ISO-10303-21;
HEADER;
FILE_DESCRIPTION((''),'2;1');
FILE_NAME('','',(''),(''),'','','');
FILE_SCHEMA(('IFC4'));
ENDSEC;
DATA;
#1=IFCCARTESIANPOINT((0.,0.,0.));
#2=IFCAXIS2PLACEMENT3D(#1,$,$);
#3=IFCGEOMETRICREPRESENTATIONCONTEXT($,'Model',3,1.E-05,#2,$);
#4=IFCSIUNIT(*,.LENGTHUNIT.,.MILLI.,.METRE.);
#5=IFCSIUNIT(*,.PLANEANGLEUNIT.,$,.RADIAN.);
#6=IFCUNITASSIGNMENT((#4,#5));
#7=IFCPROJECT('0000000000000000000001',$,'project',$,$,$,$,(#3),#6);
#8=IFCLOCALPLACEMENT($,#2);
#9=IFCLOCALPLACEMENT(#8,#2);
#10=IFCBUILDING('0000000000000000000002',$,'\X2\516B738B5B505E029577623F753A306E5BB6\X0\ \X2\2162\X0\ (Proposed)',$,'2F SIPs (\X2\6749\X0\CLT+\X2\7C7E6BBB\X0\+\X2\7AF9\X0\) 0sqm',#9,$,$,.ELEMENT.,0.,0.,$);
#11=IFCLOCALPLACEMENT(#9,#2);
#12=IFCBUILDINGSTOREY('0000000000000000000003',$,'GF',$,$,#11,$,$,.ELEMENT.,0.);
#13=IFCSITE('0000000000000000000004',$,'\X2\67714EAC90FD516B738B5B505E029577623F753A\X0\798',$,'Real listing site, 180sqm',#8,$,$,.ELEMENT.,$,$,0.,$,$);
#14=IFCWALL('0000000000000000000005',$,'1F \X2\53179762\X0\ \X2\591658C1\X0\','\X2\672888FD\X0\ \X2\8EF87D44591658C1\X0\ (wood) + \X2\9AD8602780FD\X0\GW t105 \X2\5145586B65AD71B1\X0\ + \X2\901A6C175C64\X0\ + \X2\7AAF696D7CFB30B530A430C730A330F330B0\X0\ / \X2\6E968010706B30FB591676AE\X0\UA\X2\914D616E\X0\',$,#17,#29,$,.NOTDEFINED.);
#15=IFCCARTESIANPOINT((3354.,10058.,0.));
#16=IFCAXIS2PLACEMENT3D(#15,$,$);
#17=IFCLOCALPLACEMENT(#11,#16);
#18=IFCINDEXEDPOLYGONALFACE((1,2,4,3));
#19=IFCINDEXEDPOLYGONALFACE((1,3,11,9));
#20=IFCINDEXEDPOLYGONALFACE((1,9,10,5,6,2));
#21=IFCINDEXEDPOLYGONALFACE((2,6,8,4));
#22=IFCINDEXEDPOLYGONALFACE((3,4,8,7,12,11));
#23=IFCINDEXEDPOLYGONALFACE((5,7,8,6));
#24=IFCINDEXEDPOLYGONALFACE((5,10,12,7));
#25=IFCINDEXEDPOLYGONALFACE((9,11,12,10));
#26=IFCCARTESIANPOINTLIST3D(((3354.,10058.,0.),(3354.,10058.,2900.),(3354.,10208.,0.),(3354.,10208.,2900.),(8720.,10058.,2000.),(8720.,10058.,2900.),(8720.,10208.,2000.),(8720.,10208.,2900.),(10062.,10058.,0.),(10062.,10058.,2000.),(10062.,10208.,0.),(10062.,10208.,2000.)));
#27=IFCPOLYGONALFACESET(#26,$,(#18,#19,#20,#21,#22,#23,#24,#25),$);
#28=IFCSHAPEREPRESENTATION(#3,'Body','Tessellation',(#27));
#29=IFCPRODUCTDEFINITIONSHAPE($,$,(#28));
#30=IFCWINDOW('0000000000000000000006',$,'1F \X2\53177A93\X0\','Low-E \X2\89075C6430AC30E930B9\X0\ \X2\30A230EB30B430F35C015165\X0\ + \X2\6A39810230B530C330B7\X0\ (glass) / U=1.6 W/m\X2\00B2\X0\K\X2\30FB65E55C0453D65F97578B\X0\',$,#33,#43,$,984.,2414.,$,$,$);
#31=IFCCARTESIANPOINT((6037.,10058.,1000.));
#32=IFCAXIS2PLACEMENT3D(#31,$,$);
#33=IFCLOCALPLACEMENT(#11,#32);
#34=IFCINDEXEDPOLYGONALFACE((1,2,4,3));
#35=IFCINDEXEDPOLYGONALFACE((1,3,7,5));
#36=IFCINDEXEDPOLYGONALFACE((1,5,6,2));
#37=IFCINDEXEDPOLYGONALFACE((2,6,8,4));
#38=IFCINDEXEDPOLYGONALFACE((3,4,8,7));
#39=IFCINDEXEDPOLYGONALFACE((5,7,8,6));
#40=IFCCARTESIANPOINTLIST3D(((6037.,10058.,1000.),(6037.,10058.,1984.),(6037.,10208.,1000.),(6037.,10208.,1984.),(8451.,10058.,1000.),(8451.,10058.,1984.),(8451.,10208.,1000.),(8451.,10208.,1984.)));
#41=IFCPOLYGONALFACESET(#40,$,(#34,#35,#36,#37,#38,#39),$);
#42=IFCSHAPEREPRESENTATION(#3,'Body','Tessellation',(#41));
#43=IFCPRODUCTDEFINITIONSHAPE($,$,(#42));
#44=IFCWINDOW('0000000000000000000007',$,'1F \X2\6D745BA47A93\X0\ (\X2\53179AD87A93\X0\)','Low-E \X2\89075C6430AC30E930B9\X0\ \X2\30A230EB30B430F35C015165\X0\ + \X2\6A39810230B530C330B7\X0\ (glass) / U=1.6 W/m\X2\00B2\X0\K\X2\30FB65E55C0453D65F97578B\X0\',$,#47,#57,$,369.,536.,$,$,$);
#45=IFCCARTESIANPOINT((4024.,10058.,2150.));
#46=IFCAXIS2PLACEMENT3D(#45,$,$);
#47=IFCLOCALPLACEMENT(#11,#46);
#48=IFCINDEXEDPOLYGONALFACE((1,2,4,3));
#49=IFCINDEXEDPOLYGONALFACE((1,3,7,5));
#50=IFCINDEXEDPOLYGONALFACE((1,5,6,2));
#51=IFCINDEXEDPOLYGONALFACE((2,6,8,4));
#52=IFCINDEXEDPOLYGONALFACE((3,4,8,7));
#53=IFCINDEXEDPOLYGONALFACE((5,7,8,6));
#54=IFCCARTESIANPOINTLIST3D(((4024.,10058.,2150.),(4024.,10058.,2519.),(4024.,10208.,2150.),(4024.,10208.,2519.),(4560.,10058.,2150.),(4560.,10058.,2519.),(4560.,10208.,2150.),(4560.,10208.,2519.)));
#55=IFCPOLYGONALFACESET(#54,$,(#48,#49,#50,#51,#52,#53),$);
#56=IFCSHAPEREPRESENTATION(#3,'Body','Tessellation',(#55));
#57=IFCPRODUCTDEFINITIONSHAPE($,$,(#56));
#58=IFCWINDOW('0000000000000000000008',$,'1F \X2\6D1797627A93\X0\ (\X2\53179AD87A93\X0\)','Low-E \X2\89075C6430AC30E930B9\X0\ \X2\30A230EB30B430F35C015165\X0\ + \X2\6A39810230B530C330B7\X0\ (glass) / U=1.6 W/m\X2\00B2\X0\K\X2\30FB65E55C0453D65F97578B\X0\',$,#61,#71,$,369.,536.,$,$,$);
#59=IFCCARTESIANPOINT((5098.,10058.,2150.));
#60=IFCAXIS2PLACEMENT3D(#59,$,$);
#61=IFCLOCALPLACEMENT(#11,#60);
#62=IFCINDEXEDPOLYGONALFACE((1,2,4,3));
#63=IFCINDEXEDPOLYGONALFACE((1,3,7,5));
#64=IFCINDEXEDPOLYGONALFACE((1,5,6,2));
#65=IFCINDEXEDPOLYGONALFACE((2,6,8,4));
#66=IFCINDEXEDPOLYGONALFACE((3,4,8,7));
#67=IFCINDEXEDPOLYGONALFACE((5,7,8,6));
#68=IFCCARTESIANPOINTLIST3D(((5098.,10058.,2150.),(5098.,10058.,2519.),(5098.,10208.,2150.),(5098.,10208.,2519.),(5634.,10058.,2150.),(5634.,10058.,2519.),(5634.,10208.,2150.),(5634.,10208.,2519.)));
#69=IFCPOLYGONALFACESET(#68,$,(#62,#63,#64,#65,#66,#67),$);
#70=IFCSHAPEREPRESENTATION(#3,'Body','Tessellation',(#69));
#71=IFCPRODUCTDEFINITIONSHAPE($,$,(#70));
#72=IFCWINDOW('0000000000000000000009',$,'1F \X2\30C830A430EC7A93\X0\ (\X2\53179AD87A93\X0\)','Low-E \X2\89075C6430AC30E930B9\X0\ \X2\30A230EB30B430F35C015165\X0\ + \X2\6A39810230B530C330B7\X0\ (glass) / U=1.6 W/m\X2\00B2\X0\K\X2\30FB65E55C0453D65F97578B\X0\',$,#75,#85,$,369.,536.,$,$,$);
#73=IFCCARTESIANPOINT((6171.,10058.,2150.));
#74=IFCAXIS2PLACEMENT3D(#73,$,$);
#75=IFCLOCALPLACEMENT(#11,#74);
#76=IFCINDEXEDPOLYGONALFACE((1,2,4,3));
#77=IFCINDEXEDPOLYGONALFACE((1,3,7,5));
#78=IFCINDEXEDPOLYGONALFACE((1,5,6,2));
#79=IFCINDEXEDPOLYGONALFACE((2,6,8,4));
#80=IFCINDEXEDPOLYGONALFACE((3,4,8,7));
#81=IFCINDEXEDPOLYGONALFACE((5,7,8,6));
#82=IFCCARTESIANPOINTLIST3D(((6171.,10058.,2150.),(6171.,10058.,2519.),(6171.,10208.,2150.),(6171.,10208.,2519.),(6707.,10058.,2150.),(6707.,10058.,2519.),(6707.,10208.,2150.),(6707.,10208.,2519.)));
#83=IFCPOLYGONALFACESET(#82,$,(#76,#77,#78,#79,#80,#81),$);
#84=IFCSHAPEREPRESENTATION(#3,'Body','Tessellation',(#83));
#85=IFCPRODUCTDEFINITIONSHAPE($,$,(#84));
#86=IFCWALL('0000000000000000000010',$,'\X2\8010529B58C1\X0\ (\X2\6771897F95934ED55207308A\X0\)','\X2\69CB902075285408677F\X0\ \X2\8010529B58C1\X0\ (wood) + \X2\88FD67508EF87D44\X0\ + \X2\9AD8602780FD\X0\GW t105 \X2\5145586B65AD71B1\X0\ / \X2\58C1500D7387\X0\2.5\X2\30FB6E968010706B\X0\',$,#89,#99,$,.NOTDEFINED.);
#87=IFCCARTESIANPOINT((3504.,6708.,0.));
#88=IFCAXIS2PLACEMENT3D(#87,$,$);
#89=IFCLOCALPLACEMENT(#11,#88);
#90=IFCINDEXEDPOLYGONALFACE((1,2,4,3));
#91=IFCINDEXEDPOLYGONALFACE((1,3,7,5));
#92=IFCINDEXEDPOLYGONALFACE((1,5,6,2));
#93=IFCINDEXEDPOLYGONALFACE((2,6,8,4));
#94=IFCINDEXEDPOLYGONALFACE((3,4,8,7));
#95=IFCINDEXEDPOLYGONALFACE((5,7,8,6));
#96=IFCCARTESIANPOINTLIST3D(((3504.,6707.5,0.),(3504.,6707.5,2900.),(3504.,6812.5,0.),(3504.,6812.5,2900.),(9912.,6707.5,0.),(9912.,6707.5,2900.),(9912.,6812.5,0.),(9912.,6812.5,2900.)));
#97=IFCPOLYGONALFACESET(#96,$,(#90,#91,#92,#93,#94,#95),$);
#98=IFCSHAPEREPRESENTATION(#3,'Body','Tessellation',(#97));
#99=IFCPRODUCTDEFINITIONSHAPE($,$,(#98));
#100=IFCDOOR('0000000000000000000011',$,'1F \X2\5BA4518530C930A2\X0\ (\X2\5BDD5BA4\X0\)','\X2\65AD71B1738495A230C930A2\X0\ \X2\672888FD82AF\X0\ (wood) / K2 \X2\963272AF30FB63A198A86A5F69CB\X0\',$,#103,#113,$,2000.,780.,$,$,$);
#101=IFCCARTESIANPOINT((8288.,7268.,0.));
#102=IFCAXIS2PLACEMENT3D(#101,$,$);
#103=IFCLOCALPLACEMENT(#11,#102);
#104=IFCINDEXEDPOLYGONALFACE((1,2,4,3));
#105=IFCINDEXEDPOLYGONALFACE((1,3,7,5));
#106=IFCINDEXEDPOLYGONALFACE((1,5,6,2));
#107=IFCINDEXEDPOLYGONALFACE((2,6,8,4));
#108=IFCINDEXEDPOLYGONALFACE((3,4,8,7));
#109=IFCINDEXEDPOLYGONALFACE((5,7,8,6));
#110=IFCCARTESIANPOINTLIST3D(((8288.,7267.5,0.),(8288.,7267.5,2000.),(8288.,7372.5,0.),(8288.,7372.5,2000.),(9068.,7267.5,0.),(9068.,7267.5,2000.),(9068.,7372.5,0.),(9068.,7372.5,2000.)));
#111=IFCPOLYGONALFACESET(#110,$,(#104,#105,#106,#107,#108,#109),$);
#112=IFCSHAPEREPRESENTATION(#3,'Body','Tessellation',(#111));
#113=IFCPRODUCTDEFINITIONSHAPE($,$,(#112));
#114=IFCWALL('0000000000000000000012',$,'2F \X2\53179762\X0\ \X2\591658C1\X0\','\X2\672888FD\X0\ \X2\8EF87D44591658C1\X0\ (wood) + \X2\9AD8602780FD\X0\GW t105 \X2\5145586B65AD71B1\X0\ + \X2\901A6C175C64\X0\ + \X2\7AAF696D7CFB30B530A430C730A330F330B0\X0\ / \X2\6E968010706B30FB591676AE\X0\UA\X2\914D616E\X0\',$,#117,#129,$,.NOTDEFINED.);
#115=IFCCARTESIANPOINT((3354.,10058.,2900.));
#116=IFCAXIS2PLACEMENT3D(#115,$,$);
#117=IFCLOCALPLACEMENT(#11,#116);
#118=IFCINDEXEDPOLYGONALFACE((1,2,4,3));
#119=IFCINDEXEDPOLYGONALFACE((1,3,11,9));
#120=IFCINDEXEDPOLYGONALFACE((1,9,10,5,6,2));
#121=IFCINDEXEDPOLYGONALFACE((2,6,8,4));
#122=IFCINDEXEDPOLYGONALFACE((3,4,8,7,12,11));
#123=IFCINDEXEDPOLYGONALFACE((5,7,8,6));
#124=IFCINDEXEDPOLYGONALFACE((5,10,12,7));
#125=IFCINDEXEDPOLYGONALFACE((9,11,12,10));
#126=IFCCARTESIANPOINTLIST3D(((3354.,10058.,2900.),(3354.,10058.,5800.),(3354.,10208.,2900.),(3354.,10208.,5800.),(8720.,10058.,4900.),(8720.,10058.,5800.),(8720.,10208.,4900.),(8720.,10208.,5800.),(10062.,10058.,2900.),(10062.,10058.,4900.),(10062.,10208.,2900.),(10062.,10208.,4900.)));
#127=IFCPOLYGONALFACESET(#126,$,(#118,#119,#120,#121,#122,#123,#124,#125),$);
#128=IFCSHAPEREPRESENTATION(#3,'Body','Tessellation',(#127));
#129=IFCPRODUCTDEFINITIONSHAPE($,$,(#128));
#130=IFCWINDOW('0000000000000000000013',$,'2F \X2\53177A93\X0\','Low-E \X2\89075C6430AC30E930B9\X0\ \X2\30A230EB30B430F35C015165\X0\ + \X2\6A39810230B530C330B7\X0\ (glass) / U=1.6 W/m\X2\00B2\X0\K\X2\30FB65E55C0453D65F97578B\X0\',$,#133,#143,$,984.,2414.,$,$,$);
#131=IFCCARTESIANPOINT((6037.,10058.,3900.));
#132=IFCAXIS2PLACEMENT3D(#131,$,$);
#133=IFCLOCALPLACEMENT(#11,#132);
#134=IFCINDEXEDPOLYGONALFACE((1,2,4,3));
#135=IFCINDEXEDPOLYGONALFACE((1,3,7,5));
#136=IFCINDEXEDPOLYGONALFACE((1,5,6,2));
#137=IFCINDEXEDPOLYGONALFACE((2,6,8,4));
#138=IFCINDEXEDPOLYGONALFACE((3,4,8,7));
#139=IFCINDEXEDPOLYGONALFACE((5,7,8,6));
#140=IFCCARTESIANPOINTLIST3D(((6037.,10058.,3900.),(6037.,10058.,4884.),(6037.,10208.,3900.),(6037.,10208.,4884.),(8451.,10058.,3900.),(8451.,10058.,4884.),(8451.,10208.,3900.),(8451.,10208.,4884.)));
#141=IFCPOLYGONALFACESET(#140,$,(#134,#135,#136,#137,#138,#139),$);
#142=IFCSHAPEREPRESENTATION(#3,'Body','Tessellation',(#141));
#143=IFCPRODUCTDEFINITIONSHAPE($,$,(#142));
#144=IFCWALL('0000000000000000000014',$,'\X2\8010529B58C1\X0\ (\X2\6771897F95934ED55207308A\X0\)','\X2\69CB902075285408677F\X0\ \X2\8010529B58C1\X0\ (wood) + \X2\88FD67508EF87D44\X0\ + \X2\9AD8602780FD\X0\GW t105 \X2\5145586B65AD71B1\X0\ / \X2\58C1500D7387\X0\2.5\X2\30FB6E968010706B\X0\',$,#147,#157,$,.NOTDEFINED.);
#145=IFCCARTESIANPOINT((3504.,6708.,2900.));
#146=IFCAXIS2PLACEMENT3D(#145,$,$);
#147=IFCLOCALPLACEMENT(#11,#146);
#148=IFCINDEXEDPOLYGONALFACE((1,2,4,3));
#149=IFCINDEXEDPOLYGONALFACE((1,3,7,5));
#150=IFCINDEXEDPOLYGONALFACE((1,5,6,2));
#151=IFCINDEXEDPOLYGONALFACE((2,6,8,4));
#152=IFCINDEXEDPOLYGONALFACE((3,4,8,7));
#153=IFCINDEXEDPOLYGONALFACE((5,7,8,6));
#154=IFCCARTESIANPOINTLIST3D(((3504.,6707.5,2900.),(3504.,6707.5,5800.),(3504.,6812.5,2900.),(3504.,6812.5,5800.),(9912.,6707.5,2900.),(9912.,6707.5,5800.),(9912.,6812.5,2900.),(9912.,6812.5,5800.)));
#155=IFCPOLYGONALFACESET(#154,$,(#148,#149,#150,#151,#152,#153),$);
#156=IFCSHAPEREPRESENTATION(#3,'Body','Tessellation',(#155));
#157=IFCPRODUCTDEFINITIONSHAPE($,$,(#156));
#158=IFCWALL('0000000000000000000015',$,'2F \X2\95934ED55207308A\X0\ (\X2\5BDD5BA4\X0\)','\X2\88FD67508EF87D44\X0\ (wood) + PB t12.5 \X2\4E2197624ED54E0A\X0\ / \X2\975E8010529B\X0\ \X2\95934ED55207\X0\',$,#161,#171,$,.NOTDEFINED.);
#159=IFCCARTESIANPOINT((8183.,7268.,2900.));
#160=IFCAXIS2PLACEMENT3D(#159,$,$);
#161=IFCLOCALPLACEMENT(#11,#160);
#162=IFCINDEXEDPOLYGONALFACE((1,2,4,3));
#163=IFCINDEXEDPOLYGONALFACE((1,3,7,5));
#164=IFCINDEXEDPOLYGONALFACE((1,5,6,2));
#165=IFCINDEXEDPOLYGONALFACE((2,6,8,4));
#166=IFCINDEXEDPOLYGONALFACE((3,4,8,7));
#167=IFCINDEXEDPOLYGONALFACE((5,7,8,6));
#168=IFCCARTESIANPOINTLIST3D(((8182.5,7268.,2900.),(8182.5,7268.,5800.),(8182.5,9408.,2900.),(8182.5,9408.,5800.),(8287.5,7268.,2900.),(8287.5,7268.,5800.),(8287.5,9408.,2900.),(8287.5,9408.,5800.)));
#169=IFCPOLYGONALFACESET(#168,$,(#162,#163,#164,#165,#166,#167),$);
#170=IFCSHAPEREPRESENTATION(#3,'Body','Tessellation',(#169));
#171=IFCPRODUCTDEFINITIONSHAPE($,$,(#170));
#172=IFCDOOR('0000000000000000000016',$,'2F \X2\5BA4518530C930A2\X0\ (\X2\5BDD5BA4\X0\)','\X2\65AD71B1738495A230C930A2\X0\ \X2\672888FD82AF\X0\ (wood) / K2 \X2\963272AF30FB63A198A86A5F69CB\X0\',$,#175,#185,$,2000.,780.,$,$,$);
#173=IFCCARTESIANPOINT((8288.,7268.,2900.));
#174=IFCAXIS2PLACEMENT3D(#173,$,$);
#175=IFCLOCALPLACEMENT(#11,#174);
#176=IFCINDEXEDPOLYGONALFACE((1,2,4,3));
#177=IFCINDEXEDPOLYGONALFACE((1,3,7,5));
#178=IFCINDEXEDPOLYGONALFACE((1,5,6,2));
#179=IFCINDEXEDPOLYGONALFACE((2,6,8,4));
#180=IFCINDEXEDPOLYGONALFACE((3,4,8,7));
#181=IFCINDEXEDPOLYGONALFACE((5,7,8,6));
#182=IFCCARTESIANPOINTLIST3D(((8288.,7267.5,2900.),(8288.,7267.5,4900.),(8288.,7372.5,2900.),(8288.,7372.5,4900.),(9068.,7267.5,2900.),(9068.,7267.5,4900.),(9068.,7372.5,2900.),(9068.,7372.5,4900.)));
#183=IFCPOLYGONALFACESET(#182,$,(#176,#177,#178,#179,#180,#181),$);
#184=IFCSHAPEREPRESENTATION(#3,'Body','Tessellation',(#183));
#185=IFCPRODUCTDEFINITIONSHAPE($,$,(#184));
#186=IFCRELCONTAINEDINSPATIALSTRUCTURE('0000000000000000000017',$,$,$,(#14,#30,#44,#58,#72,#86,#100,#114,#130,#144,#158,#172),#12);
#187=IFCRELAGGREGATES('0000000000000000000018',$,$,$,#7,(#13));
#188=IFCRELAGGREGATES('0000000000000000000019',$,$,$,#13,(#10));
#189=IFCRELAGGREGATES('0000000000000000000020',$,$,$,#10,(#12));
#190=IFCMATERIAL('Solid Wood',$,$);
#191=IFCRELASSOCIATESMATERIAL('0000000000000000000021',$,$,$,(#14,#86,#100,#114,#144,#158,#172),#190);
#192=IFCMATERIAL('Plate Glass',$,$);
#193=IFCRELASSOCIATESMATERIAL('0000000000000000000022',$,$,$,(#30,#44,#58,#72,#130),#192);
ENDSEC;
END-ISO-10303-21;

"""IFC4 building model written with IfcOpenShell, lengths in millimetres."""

from ifc_helpers import new_model, si_unit, frame, frame_2d, origin, place, context, project, spatial, rectangle, extrude, material, element, fill, save


model = new_model("IFC4")

# Units and contexts
model_context = context("Model", 3, precision=1e-05, world=origin())
ifc_project = project(units=[si_unit("LENGTHUNIT", "METRE", prefix="MILLI"), si_unit("PLANEANGLEUNIT", "RADIAN")], contexts=[model_context])

# Site, building, storey
site_placement = place(None, origin())
site = spatial("IfcSite", under=ifc_project, at=site_placement, Name="東京都八王子市長房町798", ObjectType="Real listing site, 180sqm", CompositionType="ELEMENT", RefElevation=0.0)
building_placement = place(site_placement, origin())
building = spatial("IfcBuilding", under=site, at=building_placement, Name="八王子市長房町の家 Ⅲ (Proposed)", ObjectType="2F SIPs (杉CLT+籾殻+竹) 0sqm", CompositionType="ELEMENT", ElevationOfRefHeight=0.0, ElevationOfTerrain=0.0)
storey_placement = place(building_placement, origin())
storey = spatial("IfcBuildingStorey", under=building, at=storey_placement, Name="GF", CompositionType="ELEMENT", Elevation=0.0)

# Wall, openings, windows
ifc_material_1 = material(Name="Solid Wood")
wall_1_placement = place(storey_placement, frame((3354.0, 10058.0, 0.0)))
wall_1 = element("IfcWall", 1, at=wall_1_placement, inside=storey, material=ifc_material_1, Name="1F 北面 外壁", Description="木製 軸組外壁 (wood) + 高性能GW t105 充填断熱 + 通気層 + 窯業系サイディング / 準耐火・外皮UA配慮", PredefinedType="NOTDEFINED", context=model_context, shape_type="SweptSolid", body=[
    extrude(rectangle(XDim=6708.0, YDim=150.0, at=frame_2d((3354.0, 75.0))), frame((3354.0, 10058.0, 0.0)), (0.0, 0.0, 1.0), 2900.0),
])
opening_1_placement = place(storey_placement, frame((6037.0, 10058.0, 1000.0)))
opening_1 = element("IfcOpeningElement", 2, at=opening_1_placement, cuts=wall_1, PredefinedType="NOTDEFINED", context=model_context, shape_type="SweptSolid", body=[
    extrude(rectangle(XDim=2414.0, YDim=150.0, at=frame_2d((1207.0, 75.0))), frame((6037.0, 10058.0, 1000.0)), (0.0, 0.0, 1.0), 984.0),
])
opening_2_placement = place(storey_placement, frame((4024.0, 10058.0, 2150.0)))
opening_2 = element("IfcOpeningElement", 3, at=opening_2_placement, cuts=wall_1, PredefinedType="NOTDEFINED", context=model_context, shape_type="SweptSolid", body=[
    extrude(rectangle(XDim=536.0, YDim=150.0, at=frame_2d((268.0, 75.0))), frame((4024.0, 10058.0, 2150.0)), (0.0, 0.0, 1.0), 369.0),
])
opening_3_placement = place(storey_placement, frame((5098.0, 10058.0, 2150.0)))
opening_3 = element("IfcOpeningElement", 4, at=opening_3_placement, cuts=wall_1, PredefinedType="NOTDEFINED", context=model_context, shape_type="SweptSolid", body=[
    extrude(rectangle(XDim=536.0, YDim=150.0, at=frame_2d((268.0, 75.0))), frame((5098.0, 10058.0, 2150.0)), (0.0, 0.0, 1.0), 369.0),
])
opening_4_placement = place(storey_placement, frame((6171.0, 10058.0, 2150.0)))
opening_4 = element("IfcOpeningElement", 5, at=opening_4_placement, cuts=wall_1, PredefinedType="NOTDEFINED", context=model_context, shape_type="SweptSolid", body=[
    extrude(rectangle(XDim=536.0, YDim=150.0, at=frame_2d((268.0, 75.0))), frame((6171.0, 10058.0, 2150.0)), (0.0, 0.0, 1.0), 369.0),
])
ifc_material_2 = material(Name="Plate Glass")
window_1_placement = place(storey_placement, frame((6037.0, 10058.0, 1000.0)))
window_1 = element("IfcWindow", 6, at=window_1_placement, inside=storey, material=ifc_material_2, Name="1F 北窓", Description="Low-E 複層ガラス アルゴン封入 + 樹脂サッシ (glass) / U=1.6 W/m²K・日射取得型", OverallHeight=984.0, OverallWidth=2414.0, context=model_context, shape_type="SweptSolid", body=[
    extrude(rectangle(XDim=2414.0, YDim=150.0, at=frame_2d((1207.0, 75.0))), frame((6037.0, 10058.0, 1000.0)), (0.0, 0.0, 1.0), 984.0),
])
fill(opening_1, window_1)
window_2_placement = place(storey_placement, frame((4024.0, 10058.0, 2150.0)))
window_2 = element("IfcWindow", 7, at=window_2_placement, inside=storey, material=ifc_material_2, Name="1F 浴室窓 (北高窓)", Description="Low-E 複層ガラス アルゴン封入 + 樹脂サッシ (glass) / U=1.6 W/m²K・日射取得型", OverallHeight=369.0, OverallWidth=536.0, context=model_context, shape_type="SweptSolid", body=[
    extrude(rectangle(XDim=536.0, YDim=150.0, at=frame_2d((268.0, 75.0))), frame((4024.0, 10058.0, 2150.0)), (0.0, 0.0, 1.0), 369.0),
])
fill(opening_2, window_2)
window_3_placement = place(storey_placement, frame((5098.0, 10058.0, 2150.0)))
window_3 = element("IfcWindow", 8, at=window_3_placement, inside=storey, material=ifc_material_2, Name="1F 洗面窓 (北高窓)", Description="Low-E 複層ガラス アルゴン封入 + 樹脂サッシ (glass) / U=1.6 W/m²K・日射取得型", OverallHeight=369.0, OverallWidth=536.0, context=model_context, shape_type="SweptSolid", body=[
    extrude(rectangle(XDim=536.0, YDim=150.0, at=frame_2d((268.0, 75.0))), frame((5098.0, 10058.0, 2150.0)), (0.0, 0.0, 1.0), 369.0),
])
fill(opening_3, window_3)
window_4_placement = place(storey_placement, frame((6171.0, 10058.0, 2150.0)))
window_4 = element("IfcWindow", 9, at=window_4_placement, inside=storey, material=ifc_material_2, Name="1F トイレ窓 (北高窓)", Description="Low-E 複層ガラス アルゴン封入 + 樹脂サッシ (glass) / U=1.6 W/m²K・日射取得型", OverallHeight=369.0, OverallWidth=536.0, context=model_context, shape_type="SweptSolid", body=[
    extrude(rectangle(XDim=536.0, YDim=150.0, at=frame_2d((268.0, 75.0))), frame((6171.0, 10058.0, 2150.0)), (0.0, 0.0, 1.0), 369.0),
])
fill(opening_4, window_4)

# Wall
wall_2_placement = place(storey_placement, frame((3504.0, 6708.0, 0.0)))
element("IfcWall", 10, at=wall_2_placement, inside=storey, material=ifc_material_1, Name="耐力壁 (東西間仕切り)", Description="構造用合板 耐力壁 (wood) + 製材軸組 + 高性能GW t105 充填断熱 / 壁倍率2.5・準耐火", PredefinedType="NOTDEFINED", context=model_context, shape_type="SweptSolid", body=[
    extrude(rectangle(XDim=6408.0, YDim=105.0, at=frame_2d((3204.0, 52.0))), frame((3504.0, 6708.0, 0.0)), (0.0, 0.0, 1.0), 2900.0),
])

# Door
door_1_placement = place(storey_placement, frame((8288.0, 7268.0, 0.0)))
element("IfcDoor", 11, at=door_1_placement, inside=storey, material=ifc_material_1, Name="1F 室内ドア (寝室)", Description="断熱玄関ドア 木製芯 (wood) / K2 防犯・採風機構", OverallHeight=2000.0, OverallWidth=780.0, context=model_context, shape_type="SweptSolid", body=[
    extrude(rectangle(XDim=780.0, YDim=105.0, at=frame_2d((390.0, 52.0))), frame((8288.0, 7268.0, 0.0)), (0.0, 0.0, 1.0), 2000.0),
])

# Wall, opening, window
wall_3_placement = place(storey_placement, frame((3354.0, 10058.0, 2900.0)))
wall_3 = element("IfcWall", 12, at=wall_3_placement, inside=storey, material=ifc_material_1, Name="2F 北面 外壁", Description="木製 軸組外壁 (wood) + 高性能GW t105 充填断熱 + 通気層 + 窯業系サイディング / 準耐火・外皮UA配慮", PredefinedType="NOTDEFINED", context=model_context, shape_type="SweptSolid", body=[
    extrude(rectangle(XDim=6708.0, YDim=150.0, at=frame_2d((3354.0, 75.0))), frame((3354.0, 10058.0, 2900.0)), (0.0, 0.0, 1.0), 2900.0),
])
opening_5_placement = place(storey_placement, frame((6037.0, 10058.0, 3900.0)))
opening_5 = element("IfcOpeningElement", 13, at=opening_5_placement, cuts=wall_3, PredefinedType="NOTDEFINED", context=model_context, shape_type="SweptSolid", body=[
    extrude(rectangle(XDim=2414.0, YDim=150.0, at=frame_2d((1207.0, 75.0))), frame((6037.0, 10058.0, 3900.0)), (0.0, 0.0, 1.0), 984.0),
])
window_5_placement = place(storey_placement, frame((6037.0, 10058.0, 3900.0)))
window_5 = element("IfcWindow", 14, at=window_5_placement, inside=storey, material=ifc_material_2, Name="2F 北窓", Description="Low-E 複層ガラス アルゴン封入 + 樹脂サッシ (glass) / U=1.6 W/m²K・日射取得型", OverallHeight=984.0, OverallWidth=2414.0, context=model_context, shape_type="SweptSolid", body=[
    extrude(rectangle(XDim=2414.0, YDim=150.0, at=frame_2d((1207.0, 75.0))), frame((6037.0, 10058.0, 3900.0)), (0.0, 0.0, 1.0), 984.0),
])
fill(opening_5, window_5)

# Walls
wall_4_placement = place(storey_placement, frame((3504.0, 6708.0, 2900.0)))
element("IfcWall", 15, at=wall_4_placement, inside=storey, material=ifc_material_1, Name="耐力壁 (東西間仕切り)", Description="構造用合板 耐力壁 (wood) + 製材軸組 + 高性能GW t105 充填断熱 / 壁倍率2.5・準耐火", PredefinedType="NOTDEFINED", context=model_context, shape_type="SweptSolid", body=[
    extrude(rectangle(XDim=6408.0, YDim=105.0, at=frame_2d((3204.0, 52.0))), frame((3504.0, 6708.0, 2900.0)), (0.0, 0.0, 1.0), 2900.0),
])
wall_5_placement = place(storey_placement, frame((8183.0, 7268.0, 2900.0)))
element("IfcWall", 16, at=wall_5_placement, inside=storey, material=ifc_material_1, Name="2F 間仕切り (寝室)", Description="製材軸組 (wood) + PB t12.5 両面仕上 / 非耐力 間仕切", PredefinedType="NOTDEFINED", context=model_context, shape_type="SweptSolid", body=[
    extrude(rectangle(XDim=105.0, YDim=2140.0, at=frame_2d((52.0, 1070.0))), frame((8183.0, 7268.0, 2900.0)), (0.0, 0.0, 1.0), 2900.0),
])

# Door
door_2_placement = place(storey_placement, frame((8288.0, 7268.0, 2900.0)))
element("IfcDoor", 17, at=door_2_placement, inside=storey, material=ifc_material_1, Name="2F 室内ドア (寝室)", Description="断熱玄関ドア 木製芯 (wood) / K2 防犯・採風機構", OverallHeight=2000.0, OverallWidth=780.0, context=model_context, shape_type="SweptSolid", body=[
    extrude(rectangle(XDim=780.0, YDim=105.0, at=frame_2d((390.0, 52.0))), frame((8288.0, 7268.0, 2900.0)), (0.0, 0.0, 1.0), 2000.0),
])

save(model, "model.ifc")
